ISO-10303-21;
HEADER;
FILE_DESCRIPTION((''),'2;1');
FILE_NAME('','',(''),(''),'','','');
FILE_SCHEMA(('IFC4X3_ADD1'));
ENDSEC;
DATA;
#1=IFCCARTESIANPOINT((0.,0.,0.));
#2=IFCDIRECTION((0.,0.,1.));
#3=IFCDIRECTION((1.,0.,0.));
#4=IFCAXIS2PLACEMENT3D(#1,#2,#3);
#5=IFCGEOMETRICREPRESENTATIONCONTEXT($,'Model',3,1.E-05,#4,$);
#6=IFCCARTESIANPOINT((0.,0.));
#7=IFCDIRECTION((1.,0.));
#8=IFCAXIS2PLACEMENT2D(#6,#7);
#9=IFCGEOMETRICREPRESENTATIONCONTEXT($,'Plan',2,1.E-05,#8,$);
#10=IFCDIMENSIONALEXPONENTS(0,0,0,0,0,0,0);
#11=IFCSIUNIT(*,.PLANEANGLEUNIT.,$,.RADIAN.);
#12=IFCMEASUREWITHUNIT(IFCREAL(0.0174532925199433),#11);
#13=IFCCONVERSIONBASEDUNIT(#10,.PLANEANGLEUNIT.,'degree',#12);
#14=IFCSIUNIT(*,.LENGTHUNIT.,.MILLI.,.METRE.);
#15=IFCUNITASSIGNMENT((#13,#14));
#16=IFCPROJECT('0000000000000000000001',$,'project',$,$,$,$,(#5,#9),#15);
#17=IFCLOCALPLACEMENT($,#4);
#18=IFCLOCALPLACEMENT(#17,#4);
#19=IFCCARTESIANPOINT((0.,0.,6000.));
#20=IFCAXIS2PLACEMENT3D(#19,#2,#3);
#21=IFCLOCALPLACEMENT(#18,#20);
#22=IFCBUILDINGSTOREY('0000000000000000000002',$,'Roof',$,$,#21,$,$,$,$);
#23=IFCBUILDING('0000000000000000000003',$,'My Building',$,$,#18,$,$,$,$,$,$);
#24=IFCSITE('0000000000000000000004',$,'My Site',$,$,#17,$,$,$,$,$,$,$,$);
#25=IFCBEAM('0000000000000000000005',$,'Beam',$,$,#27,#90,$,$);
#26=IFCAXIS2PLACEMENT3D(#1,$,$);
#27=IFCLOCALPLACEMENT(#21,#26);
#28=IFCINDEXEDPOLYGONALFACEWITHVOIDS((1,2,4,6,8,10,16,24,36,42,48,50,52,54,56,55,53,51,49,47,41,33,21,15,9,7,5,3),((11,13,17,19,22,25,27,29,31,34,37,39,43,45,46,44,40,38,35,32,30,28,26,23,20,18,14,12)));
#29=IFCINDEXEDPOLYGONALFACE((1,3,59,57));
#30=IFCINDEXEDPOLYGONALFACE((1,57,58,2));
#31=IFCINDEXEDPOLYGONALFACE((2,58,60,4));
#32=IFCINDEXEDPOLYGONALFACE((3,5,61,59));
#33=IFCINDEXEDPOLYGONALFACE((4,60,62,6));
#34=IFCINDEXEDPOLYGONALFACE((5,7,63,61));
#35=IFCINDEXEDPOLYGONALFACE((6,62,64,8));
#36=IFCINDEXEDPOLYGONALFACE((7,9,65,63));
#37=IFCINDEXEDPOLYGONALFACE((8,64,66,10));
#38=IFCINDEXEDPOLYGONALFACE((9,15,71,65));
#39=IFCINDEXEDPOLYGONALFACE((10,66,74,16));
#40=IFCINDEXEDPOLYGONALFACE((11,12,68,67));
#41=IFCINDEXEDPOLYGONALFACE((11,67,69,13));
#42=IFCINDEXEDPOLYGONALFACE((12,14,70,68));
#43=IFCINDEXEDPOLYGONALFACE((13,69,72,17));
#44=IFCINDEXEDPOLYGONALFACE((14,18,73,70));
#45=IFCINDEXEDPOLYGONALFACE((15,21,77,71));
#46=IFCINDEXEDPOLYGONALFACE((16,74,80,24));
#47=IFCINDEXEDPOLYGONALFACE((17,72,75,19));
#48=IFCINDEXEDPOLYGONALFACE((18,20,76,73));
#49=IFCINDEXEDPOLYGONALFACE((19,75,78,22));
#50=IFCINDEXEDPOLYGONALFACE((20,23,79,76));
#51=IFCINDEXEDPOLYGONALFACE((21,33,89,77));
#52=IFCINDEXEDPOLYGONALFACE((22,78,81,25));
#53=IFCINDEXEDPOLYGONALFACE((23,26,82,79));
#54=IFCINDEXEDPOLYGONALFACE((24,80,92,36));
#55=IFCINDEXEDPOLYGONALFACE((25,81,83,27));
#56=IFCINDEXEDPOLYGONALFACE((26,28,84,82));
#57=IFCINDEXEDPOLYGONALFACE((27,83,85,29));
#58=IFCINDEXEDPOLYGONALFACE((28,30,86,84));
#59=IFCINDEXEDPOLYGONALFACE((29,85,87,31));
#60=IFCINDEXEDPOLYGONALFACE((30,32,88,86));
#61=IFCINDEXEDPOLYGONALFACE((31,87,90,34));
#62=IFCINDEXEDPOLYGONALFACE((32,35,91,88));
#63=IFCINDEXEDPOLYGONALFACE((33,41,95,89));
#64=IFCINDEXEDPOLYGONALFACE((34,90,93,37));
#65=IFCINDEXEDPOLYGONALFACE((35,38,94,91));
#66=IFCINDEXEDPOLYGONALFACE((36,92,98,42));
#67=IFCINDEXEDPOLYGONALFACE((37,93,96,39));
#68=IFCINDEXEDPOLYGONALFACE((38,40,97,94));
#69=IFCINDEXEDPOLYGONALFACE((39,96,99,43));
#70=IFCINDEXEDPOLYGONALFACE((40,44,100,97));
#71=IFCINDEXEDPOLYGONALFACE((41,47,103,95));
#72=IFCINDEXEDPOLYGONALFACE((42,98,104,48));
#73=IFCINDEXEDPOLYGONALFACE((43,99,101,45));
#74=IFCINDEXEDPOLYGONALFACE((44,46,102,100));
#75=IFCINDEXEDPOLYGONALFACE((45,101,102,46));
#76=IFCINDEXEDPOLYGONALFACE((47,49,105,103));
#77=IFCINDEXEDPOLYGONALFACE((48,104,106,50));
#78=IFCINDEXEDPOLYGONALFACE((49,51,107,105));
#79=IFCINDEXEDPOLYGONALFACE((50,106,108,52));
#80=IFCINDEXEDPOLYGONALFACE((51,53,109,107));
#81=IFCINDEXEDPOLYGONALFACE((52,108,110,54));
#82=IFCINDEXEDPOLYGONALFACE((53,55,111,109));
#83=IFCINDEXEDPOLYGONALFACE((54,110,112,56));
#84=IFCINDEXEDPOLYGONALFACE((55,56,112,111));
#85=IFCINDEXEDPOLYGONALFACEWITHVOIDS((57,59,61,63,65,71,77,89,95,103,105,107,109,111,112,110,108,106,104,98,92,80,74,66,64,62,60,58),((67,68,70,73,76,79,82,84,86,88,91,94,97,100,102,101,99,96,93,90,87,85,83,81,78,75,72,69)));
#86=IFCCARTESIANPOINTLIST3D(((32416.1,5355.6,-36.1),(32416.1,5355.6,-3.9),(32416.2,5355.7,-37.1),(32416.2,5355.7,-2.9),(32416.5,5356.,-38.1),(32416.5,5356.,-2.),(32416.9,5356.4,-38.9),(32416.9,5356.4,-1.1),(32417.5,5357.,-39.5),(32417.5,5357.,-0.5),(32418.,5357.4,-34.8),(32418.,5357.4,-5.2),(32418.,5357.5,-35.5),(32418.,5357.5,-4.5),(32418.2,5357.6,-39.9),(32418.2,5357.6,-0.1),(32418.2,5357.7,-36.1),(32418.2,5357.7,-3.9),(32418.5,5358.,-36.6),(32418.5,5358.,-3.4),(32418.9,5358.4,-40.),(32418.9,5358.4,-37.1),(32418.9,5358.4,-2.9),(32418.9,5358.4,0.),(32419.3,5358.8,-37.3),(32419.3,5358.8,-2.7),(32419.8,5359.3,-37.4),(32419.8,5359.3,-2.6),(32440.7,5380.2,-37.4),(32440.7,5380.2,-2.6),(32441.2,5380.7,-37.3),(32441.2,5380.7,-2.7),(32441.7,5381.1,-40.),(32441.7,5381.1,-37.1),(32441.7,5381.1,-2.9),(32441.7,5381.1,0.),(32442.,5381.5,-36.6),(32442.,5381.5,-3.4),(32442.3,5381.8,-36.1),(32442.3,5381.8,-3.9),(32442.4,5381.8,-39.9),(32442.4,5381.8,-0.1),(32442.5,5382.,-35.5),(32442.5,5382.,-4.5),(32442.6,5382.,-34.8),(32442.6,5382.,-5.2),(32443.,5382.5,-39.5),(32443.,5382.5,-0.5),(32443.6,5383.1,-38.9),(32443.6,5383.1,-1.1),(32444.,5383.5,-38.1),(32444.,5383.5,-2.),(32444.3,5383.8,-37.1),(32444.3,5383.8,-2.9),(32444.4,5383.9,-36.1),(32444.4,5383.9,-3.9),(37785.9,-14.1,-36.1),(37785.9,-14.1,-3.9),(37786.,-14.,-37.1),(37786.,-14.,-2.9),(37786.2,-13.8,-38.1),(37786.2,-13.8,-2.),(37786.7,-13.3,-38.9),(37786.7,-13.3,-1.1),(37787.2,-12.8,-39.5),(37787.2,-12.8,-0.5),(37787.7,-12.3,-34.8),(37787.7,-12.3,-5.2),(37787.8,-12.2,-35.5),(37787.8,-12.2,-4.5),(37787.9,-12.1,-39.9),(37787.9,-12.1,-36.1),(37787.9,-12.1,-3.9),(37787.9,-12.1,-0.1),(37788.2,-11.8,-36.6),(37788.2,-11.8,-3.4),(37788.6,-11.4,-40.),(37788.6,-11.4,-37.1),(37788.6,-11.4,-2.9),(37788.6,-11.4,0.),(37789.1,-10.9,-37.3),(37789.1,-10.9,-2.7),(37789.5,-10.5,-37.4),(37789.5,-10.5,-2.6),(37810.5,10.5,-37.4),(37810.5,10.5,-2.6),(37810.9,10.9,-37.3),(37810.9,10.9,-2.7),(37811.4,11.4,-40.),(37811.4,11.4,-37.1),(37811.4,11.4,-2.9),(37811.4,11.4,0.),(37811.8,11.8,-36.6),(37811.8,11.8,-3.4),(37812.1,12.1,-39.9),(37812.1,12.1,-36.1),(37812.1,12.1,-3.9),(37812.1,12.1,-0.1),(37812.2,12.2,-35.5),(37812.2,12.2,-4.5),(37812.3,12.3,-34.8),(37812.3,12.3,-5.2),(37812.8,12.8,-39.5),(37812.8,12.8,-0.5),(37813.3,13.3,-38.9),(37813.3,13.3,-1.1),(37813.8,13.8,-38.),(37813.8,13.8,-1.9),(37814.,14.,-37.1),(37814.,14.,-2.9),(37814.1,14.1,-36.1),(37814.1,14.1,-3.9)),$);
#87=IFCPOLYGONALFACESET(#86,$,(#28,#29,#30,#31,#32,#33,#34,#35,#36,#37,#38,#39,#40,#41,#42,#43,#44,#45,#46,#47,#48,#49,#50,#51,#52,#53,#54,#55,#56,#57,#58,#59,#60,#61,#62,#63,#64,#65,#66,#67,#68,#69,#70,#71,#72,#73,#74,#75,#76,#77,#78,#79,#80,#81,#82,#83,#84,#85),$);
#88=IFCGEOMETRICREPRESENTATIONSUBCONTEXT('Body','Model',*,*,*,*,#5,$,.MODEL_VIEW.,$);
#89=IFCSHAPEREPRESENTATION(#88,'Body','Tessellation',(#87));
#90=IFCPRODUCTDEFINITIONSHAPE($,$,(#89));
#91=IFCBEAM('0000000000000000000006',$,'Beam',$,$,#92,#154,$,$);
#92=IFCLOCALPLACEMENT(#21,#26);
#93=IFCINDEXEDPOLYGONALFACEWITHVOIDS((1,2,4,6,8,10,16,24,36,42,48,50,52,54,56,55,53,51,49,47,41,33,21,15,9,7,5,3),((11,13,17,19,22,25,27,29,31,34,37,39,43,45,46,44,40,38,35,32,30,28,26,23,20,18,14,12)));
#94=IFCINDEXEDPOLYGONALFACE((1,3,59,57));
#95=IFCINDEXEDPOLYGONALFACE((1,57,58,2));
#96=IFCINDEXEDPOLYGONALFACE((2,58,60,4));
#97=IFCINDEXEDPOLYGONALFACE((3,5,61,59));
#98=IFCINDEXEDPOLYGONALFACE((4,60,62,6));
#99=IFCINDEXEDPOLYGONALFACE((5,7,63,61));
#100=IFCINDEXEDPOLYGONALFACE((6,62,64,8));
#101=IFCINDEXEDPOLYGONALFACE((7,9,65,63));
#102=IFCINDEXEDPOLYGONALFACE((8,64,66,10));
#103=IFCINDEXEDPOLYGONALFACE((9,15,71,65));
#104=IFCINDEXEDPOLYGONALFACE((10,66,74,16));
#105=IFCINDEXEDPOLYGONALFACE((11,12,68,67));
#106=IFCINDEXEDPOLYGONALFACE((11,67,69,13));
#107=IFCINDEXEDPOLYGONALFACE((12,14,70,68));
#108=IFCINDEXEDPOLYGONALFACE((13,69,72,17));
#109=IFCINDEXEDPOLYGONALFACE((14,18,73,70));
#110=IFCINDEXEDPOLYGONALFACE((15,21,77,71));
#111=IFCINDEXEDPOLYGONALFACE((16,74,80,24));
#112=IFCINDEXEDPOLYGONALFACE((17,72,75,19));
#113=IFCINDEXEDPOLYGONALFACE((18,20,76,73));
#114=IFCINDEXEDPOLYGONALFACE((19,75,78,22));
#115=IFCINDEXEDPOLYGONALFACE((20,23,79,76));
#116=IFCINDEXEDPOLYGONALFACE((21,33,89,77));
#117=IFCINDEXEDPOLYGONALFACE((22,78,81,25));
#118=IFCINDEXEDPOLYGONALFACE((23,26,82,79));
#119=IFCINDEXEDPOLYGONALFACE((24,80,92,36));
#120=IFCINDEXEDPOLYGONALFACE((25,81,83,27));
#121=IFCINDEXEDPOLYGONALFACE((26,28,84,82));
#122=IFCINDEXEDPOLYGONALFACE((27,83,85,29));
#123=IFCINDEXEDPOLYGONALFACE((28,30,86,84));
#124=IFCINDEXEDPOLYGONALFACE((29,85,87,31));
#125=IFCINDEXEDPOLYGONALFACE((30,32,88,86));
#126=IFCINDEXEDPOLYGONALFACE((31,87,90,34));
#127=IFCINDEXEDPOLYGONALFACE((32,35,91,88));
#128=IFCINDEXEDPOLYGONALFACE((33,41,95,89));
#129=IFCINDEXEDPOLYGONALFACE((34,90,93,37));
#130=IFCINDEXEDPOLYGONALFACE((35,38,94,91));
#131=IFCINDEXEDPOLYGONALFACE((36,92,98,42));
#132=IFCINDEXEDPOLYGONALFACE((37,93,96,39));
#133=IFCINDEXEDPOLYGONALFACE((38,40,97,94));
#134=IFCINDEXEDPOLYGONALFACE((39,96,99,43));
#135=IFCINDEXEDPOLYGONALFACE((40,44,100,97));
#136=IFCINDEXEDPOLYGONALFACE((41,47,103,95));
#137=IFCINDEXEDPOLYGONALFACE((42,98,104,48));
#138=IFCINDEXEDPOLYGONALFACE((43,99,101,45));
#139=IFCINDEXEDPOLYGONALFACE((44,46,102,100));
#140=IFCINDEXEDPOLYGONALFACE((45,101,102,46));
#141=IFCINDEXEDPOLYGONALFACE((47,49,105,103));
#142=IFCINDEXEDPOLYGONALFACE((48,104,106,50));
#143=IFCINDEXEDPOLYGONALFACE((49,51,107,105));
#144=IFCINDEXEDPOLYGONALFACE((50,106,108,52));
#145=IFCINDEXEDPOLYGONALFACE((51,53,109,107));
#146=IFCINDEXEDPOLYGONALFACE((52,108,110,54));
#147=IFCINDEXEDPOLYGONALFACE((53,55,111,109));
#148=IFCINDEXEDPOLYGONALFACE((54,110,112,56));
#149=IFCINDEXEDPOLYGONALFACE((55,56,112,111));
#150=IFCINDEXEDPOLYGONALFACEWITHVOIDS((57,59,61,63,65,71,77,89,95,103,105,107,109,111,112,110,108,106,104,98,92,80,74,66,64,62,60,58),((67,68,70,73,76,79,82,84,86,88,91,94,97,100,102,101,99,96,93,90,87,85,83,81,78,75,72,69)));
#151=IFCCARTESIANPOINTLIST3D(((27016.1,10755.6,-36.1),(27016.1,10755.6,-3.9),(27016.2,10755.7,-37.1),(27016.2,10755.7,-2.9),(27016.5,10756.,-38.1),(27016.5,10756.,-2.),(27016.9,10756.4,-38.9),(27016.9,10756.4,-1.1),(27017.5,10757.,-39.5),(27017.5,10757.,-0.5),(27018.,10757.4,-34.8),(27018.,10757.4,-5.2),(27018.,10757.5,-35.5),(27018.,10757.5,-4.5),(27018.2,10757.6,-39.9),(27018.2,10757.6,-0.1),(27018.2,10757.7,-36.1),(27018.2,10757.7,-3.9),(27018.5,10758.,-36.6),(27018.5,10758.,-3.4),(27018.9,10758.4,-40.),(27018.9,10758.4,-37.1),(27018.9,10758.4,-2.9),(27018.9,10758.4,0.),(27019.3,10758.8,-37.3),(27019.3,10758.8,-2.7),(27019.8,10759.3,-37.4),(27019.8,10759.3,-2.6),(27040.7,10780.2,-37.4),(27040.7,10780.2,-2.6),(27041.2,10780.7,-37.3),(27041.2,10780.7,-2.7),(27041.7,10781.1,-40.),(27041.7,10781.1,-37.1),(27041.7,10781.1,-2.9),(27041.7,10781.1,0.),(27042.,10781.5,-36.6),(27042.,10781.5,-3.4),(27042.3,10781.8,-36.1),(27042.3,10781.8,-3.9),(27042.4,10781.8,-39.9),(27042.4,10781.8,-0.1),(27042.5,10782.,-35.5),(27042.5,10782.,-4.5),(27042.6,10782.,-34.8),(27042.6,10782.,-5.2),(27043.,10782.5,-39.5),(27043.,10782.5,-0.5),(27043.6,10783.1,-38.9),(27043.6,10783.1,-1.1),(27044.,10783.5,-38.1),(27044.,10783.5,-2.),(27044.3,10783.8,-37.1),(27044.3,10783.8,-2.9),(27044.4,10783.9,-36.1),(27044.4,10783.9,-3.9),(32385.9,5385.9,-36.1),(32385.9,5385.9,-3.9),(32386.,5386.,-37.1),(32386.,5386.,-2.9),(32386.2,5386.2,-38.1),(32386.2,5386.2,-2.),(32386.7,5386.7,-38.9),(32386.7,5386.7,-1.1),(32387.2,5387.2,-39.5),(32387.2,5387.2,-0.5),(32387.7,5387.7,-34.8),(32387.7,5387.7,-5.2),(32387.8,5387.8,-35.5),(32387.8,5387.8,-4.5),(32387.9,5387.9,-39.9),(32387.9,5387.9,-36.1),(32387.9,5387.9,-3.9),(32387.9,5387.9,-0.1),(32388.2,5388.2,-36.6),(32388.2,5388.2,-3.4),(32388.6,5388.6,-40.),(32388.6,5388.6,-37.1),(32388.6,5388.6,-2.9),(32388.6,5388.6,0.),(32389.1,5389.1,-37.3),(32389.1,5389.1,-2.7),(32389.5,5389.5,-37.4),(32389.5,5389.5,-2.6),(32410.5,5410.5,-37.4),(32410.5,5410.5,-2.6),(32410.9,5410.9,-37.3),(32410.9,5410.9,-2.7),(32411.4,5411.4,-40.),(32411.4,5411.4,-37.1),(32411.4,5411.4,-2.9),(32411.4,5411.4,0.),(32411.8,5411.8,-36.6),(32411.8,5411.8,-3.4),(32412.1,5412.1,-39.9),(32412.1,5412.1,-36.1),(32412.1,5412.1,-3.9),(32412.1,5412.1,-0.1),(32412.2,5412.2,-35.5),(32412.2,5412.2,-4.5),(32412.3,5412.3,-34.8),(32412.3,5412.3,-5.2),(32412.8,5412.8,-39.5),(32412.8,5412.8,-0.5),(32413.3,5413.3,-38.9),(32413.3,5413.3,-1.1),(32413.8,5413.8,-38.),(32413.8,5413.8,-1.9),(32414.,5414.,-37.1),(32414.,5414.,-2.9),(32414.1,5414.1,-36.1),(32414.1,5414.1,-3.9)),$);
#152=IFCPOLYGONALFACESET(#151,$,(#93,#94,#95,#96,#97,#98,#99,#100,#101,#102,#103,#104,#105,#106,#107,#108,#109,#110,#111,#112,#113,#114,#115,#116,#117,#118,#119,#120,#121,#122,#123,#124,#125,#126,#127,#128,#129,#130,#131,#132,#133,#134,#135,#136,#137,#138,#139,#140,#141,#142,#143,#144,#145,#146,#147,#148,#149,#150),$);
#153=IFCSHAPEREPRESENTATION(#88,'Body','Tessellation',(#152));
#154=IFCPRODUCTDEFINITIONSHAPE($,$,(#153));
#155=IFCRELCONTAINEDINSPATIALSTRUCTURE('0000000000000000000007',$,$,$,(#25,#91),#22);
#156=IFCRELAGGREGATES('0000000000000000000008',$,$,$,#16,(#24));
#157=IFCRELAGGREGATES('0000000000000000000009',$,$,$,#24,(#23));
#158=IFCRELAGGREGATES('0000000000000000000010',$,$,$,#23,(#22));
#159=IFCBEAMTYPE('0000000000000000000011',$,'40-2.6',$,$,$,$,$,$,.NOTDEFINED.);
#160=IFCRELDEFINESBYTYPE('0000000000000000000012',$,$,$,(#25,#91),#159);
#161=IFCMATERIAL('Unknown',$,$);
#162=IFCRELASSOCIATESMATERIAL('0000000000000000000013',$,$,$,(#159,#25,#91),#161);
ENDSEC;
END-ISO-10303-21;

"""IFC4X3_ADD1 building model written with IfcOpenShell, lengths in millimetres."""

from ifc_helpers import new_model, entity, si_unit, converted_unit, frame, origin_with_axes, origin_2d_with_axis, place, context, subcontext, project, spatial, hollow_rectangle, extrude, material, material_profile, profile_set, profile_usage, type_object, element, save


model = new_model("IFC4X3_ADD1")

# Units and contexts
model_context = context("Model", 3, precision=1e-05, world=origin_with_axes())
plan_context = context("Plan", 2, precision=1e-05, world=origin_2d_with_axis())
body_context = subcontext(model_context, "Body", "Model", "MODEL_VIEW")
ifc_project = project(units=[converted_unit("PLANEANGLEUNIT", "degree", entity("IfcReal", 0.0174532925199433), si_unit("PLANEANGLEUNIT", "RADIAN"), dimensions=[0, 0, 0, 0, 0, 0, 0]), si_unit("LENGTHUNIT", "METRE", prefix="MILLI")], contexts=[model_context, plan_context])

# Site, building, storey
site_placement = place(None, origin_with_axes())
site = spatial("IfcSite", under=ifc_project, at=site_placement, Name="My Site")
building_placement = place(site_placement, origin_with_axes())
building = spatial("IfcBuilding", under=site, at=building_placement, Name="My Building")
storey_placement = place(building_placement, frame((0.0, 0.0, 6000.0), z_axis=(0.0, 0.0, 1.0), x_axis=(1.0, 0.0, 0.0)))
storey = spatial("IfcBuildingStorey", under=building, at=storey_placement, Name="Roof")

# Beams
ifc_material = material(Name="Unknown")
ifc_material_profile_1 = material_profile(ifc_material, hollow_rectangle(XDim=40.0, YDim=40.0, WallThickness=2.6, InnerFilletRadius=2.6, OuterFilletRadius=3.9))
ifc_profile_set_1 = profile_set([ifc_material_profile_1])
ifc_profile_usage_1 = profile_usage(ifc_profile_set_1, cardinal=8)
beam_type_1 = type_object("IfcBeamType", Name="40-2.6", PredefinedType="NOTDEFINED", material=ifc_profile_set_1)
beam_1_placement = place(storey_placement, frame((37800.0, 0.0, 0.0), z_axis=(-0.707107, 0.707107, 0.0), x_axis=(-0.707107, -0.707107, 0.0)))
element("IfcBeam", 1, at=beam_1_placement, inside=storey, type_object=beam_type_1, material=ifc_profile_usage_1, Name="Beam", context=body_context, shape_type="SweptSolid", body=[
    extrude(hollow_rectangle(XDim=40.0, YDim=40.0, WallThickness=2.6, InnerFilletRadius=2.6, OuterFilletRadius=3.9), frame((0.0, -20.0, 0.0), z_axis=(0.0, 0.0, 1.0), x_axis=(1.0, 0.0, 0.0)), (0.0, 0.0, 1.0), 7594.0),
])
ifc_profile_usage_2 = profile_usage(ifc_profile_set_1, cardinal=8)
beam_2_placement = place(storey_placement, frame((32400.0, 5400.0, 0.0), z_axis=(-0.707107, 0.707107, 0.0), x_axis=(-0.707107, -0.707107, 0.0)))
element("IfcBeam", 2, at=beam_2_placement, inside=storey, type_object=beam_type_1, material=ifc_profile_usage_2, Name="Beam", context=body_context, shape_type="SweptSolid", body=[
    extrude(hollow_rectangle(XDim=40.0, YDim=40.0, WallThickness=2.6, InnerFilletRadius=2.6, OuterFilletRadius=3.9), frame((0.0, -20.0, 0.0), z_axis=(0.0, 0.0, 1.0), x_axis=(1.0, 0.0, 0.0)), (0.0, 0.0, 1.0), 7594.0),
])

save(model, "model.ifc")
